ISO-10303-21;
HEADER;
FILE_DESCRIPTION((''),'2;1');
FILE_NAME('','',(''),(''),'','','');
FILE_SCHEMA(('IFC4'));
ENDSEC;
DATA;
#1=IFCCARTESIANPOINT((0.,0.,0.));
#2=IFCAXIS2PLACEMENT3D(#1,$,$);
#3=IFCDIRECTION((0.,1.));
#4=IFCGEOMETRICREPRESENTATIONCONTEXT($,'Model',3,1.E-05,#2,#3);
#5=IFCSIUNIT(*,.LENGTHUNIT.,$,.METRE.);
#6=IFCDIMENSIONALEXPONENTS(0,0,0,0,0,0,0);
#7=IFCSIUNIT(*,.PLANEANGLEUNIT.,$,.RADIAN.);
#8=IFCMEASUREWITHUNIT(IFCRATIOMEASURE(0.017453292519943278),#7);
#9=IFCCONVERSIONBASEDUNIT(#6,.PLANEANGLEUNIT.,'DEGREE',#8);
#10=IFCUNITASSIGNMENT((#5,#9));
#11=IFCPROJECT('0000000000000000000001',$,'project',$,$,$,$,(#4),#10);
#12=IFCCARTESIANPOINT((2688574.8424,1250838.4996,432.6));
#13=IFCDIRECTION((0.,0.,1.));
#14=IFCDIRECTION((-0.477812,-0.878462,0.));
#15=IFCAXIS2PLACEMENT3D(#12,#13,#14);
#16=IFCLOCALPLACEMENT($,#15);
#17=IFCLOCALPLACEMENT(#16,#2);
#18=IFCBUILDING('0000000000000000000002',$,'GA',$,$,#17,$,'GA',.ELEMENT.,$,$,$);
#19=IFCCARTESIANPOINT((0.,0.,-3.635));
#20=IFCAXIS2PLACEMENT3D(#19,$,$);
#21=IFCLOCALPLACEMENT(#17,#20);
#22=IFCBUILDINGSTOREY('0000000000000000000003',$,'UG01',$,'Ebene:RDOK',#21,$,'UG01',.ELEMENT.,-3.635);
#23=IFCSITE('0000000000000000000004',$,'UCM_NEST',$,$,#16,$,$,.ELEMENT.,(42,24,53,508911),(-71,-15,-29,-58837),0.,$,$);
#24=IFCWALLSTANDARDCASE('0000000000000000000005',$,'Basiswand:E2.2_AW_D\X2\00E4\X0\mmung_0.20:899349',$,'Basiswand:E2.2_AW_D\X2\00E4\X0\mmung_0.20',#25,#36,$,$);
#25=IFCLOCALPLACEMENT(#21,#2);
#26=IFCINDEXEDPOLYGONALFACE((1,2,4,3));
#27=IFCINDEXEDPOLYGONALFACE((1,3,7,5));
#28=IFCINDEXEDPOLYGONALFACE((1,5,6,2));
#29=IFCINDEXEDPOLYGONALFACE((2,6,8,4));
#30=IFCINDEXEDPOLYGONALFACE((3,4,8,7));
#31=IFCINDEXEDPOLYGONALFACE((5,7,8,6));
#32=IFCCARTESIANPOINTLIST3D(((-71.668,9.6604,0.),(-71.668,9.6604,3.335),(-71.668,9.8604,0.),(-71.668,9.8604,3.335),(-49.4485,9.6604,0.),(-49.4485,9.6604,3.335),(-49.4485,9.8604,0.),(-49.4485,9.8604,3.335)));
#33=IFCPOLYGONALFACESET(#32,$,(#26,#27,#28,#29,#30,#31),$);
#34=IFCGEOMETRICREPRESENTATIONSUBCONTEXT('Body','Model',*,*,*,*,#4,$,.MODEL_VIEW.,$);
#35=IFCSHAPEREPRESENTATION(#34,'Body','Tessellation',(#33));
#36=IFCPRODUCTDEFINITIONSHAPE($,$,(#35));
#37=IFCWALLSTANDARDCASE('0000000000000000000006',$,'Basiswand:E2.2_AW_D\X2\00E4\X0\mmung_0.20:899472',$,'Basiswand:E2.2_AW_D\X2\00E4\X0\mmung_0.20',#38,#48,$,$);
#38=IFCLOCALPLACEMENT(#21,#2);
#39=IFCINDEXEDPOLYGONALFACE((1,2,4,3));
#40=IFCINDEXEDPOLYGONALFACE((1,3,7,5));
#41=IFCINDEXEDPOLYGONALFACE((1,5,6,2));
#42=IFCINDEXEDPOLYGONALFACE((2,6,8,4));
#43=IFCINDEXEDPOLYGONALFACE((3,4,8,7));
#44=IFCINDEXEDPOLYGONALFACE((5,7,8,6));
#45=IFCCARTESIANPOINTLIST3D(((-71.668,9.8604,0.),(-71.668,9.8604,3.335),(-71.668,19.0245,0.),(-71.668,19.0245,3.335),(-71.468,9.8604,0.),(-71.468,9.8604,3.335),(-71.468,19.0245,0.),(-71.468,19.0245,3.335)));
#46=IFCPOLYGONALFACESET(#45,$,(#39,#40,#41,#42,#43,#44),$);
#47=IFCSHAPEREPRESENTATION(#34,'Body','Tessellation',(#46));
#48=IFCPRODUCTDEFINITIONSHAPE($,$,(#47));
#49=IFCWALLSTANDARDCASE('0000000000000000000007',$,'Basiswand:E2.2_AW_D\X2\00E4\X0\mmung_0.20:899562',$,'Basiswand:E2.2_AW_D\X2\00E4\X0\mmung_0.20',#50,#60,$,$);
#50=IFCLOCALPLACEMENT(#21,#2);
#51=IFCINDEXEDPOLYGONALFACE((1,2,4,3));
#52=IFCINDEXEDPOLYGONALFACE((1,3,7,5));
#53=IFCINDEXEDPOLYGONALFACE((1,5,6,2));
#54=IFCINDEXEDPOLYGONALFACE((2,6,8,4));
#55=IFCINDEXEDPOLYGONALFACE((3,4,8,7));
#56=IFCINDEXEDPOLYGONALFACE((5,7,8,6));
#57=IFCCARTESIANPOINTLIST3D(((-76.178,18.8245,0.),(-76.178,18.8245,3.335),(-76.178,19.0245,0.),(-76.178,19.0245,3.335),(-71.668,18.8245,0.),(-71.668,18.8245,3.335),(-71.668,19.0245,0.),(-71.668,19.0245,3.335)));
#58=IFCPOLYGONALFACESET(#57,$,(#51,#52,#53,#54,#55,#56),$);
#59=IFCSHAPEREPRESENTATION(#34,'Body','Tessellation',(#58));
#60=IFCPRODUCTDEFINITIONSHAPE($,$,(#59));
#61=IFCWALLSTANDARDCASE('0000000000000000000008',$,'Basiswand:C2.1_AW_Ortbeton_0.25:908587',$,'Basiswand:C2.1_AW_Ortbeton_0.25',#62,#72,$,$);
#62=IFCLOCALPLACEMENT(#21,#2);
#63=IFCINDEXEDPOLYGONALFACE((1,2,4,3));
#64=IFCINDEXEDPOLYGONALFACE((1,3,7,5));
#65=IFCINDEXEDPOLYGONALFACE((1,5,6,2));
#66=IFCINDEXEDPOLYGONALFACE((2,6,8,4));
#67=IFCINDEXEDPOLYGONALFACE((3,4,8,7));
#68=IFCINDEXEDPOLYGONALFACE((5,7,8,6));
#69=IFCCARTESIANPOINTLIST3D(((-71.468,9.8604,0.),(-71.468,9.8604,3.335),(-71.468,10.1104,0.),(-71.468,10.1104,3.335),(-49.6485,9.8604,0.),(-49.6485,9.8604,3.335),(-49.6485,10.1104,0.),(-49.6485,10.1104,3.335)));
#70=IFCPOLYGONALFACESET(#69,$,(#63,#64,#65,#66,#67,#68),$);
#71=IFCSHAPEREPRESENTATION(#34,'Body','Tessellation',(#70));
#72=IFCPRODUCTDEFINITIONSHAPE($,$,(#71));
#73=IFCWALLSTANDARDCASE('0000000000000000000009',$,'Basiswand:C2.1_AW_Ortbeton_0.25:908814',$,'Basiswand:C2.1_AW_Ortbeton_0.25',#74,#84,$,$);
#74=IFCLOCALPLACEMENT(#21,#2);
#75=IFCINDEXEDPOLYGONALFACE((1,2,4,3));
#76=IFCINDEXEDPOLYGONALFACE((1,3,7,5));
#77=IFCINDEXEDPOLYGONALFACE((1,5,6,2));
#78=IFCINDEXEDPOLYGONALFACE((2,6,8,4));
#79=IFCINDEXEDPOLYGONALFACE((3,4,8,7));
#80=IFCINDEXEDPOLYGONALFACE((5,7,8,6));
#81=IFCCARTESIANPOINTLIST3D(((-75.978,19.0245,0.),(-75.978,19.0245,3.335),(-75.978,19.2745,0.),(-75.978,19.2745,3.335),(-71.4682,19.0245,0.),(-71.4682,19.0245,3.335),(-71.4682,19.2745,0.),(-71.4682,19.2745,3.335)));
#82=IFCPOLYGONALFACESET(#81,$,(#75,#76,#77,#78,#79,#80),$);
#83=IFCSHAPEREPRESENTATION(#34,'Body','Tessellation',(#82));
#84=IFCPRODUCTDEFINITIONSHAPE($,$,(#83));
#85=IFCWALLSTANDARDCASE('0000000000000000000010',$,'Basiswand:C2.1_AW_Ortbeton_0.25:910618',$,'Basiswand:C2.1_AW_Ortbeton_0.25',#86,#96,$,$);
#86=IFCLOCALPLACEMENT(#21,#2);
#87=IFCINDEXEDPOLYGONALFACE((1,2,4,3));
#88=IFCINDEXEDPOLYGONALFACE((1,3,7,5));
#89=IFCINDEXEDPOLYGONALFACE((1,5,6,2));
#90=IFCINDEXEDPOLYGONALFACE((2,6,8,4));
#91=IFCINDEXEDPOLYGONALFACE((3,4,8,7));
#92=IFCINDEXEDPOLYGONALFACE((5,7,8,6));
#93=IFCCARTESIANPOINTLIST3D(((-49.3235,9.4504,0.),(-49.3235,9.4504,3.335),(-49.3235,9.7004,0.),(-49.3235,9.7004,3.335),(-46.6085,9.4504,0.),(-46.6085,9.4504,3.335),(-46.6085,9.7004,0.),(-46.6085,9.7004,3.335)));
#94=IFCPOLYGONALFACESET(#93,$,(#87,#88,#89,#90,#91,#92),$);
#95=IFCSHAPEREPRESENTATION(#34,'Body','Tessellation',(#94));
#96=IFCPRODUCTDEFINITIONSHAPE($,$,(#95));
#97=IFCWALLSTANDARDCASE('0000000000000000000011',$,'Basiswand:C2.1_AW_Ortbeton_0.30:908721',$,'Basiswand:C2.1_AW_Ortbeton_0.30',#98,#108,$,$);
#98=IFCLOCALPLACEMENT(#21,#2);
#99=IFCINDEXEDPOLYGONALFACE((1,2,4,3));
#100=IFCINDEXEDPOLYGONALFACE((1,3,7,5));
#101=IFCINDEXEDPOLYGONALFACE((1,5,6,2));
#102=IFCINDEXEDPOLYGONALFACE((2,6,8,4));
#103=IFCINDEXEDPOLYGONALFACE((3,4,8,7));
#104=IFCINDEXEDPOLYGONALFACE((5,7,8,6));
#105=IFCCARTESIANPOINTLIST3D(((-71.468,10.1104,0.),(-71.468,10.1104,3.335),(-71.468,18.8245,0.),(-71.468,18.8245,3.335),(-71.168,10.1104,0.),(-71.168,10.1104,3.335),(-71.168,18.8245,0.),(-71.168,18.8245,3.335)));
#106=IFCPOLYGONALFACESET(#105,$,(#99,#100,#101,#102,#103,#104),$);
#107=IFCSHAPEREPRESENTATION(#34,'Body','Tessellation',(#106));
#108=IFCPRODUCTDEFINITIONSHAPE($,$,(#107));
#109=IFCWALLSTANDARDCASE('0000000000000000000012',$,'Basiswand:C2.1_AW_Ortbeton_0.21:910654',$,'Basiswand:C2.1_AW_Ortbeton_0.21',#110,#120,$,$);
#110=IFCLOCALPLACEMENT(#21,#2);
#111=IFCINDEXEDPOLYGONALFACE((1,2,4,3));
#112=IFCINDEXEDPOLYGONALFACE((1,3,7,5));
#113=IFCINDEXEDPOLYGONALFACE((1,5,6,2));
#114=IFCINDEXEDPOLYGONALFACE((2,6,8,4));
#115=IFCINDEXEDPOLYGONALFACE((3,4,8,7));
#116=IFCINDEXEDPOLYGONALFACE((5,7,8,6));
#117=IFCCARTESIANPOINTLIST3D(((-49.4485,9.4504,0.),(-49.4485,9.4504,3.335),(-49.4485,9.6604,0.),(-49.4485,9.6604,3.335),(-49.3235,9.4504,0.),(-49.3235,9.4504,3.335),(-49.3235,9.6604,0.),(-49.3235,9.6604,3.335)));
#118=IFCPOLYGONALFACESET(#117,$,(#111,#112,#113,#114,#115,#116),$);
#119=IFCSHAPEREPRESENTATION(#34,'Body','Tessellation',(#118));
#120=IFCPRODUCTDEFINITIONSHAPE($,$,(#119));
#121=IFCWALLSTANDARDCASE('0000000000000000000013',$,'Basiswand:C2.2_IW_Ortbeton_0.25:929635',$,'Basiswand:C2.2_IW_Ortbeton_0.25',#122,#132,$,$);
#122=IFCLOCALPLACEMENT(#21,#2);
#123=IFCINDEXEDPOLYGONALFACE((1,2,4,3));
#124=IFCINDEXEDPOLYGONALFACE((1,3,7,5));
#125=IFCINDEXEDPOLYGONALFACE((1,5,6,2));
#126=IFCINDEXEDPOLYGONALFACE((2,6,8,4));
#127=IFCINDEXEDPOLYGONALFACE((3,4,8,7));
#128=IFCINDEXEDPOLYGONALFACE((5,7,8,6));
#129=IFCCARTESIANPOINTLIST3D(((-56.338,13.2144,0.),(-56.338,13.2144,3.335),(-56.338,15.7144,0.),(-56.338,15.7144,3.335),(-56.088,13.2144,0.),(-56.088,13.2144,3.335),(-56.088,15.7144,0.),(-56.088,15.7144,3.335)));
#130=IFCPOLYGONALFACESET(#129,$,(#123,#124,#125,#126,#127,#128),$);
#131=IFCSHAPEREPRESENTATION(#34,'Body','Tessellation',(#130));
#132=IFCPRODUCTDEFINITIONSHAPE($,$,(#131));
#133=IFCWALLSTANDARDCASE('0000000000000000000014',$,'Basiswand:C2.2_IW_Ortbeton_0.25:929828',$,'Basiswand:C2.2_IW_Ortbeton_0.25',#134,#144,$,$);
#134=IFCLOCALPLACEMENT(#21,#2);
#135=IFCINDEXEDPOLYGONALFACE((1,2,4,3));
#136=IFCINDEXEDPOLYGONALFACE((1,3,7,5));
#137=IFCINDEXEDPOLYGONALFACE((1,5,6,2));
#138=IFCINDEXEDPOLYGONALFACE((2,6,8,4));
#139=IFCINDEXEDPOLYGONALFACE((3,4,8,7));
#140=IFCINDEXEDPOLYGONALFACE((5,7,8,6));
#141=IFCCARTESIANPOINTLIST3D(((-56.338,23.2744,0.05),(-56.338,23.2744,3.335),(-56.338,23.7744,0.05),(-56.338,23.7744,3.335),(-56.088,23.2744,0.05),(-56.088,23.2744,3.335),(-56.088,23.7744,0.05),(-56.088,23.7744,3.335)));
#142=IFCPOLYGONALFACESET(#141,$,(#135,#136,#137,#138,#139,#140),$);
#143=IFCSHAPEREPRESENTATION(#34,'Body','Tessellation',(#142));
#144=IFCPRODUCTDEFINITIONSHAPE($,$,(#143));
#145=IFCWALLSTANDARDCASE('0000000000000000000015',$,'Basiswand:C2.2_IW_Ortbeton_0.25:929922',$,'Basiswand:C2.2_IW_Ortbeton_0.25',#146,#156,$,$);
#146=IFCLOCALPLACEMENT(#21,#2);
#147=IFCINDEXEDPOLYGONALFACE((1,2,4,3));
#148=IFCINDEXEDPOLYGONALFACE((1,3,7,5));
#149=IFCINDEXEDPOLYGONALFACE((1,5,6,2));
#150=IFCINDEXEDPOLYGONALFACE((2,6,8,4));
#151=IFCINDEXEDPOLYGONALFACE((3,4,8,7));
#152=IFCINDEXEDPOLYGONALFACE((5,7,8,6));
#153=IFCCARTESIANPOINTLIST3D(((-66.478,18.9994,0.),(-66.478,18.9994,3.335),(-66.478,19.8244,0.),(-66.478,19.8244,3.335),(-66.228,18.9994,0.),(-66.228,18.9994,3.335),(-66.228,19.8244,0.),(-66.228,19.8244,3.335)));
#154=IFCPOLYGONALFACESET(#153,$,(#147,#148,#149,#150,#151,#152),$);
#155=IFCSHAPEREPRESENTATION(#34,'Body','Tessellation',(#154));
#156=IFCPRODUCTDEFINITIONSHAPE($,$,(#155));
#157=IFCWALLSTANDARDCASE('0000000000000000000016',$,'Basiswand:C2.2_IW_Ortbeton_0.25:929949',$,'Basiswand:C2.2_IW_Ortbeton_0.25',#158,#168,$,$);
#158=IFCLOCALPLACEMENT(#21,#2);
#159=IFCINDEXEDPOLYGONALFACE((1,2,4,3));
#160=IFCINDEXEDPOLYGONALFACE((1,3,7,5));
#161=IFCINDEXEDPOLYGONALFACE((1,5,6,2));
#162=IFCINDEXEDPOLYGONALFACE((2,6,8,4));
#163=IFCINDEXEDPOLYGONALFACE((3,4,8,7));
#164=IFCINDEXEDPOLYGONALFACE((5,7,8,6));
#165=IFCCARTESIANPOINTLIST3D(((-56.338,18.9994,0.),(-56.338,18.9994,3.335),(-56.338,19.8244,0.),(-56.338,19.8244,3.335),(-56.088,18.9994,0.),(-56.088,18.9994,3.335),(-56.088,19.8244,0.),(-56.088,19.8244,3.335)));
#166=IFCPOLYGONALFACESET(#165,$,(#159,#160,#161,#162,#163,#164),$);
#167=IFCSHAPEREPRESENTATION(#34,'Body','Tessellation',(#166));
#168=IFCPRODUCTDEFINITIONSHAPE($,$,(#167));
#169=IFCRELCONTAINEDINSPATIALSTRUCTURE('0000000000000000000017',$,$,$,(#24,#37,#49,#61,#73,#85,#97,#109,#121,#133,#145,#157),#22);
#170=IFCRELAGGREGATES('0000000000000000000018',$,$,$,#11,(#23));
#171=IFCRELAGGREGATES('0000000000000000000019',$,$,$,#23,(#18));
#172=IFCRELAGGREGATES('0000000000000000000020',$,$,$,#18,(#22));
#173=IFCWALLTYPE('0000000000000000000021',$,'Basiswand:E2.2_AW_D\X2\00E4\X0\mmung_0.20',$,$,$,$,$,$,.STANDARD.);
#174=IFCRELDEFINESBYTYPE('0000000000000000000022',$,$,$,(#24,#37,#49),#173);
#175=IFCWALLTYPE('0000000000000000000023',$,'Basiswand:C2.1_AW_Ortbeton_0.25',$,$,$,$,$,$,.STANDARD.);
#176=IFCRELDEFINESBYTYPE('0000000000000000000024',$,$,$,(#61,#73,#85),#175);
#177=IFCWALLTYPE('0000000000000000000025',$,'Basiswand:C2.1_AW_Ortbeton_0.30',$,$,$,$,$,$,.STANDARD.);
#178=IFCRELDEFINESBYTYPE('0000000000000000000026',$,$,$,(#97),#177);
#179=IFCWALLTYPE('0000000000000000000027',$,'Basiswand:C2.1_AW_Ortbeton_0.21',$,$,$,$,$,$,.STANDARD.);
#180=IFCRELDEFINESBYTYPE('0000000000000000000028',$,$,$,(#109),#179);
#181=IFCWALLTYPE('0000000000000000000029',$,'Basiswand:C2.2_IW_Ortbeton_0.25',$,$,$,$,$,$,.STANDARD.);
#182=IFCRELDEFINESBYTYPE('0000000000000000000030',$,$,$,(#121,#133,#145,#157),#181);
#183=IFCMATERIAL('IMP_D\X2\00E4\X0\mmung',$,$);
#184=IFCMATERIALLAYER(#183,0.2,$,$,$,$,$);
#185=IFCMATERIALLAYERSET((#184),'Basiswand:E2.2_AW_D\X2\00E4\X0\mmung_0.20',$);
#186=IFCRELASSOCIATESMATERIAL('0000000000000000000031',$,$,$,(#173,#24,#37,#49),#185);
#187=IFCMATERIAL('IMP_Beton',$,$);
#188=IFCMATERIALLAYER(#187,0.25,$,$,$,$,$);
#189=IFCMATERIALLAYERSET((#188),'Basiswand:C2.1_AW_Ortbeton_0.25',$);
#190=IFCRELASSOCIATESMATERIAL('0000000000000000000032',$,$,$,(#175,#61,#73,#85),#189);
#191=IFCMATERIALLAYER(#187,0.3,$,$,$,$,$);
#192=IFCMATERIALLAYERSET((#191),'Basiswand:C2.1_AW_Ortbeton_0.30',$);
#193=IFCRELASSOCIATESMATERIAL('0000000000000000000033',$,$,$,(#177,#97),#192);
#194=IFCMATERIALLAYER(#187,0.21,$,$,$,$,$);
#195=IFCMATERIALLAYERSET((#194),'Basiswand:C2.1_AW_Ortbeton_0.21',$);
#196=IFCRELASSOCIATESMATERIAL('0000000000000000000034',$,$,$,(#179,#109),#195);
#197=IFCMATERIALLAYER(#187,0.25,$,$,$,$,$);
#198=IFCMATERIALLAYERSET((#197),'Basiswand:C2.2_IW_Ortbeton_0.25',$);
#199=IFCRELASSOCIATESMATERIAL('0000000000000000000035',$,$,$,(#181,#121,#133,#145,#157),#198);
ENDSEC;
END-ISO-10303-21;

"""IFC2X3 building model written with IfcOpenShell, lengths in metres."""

from ifc_helpers import new_model, entity, si_unit, converted_unit, direction, frame, frame_2d, origin, place, context, subcontext, project, spatial, polyline, rectangle, extrude, clip, bounded_halfspace, material, layer, layer_set, layer_usage, type_object, element, save


model = new_model("IFC2X3")

# Units and contexts
model_context = context("Model", 3, precision=1e-05, world=origin(), true_north=direction((0.0, 1.0)))
body_context = subcontext(model_context, "Body", "Model", "MODEL_VIEW")
ifc_project = project(units=[si_unit("LENGTHUNIT", "METRE"), converted_unit("PLANEANGLEUNIT", "DEGREE", entity("IfcRatioMeasure", 0.017453292519943278), si_unit("PLANEANGLEUNIT", "RADIAN"), dimensions=[0, 0, 0, 0, 0, 0, 0])], contexts=[model_context])

# Site, building, storey
site_placement = place(None, frame((2688574.8424, 1250838.4996, 432.6), z_axis=(0.0, 0.0, 1.0), x_axis=(-0.477812, -0.878462, 0.0)))
site = spatial("IfcSite", under=ifc_project, at=site_placement, Name="UCM_NEST", CompositionType="ELEMENT", RefLatitude=(42, 24, 53, 508911), RefLongitude=(-71, -15, -29, -58837), RefElevation=0.0)
building_placement = place(site_placement, origin())
building = spatial("IfcBuilding", under=site, at=building_placement, Name="GA", LongName="GA", CompositionType="ELEMENT")
storey_placement = place(building_placement, frame((0.0, 0.0, -3.635)))
storey = spatial("IfcBuildingStorey", under=building, at=storey_placement, Name="UG01", ObjectType="Ebene:RDOK", LongName="UG01", CompositionType="ELEMENT", Elevation=-3.635)

# Walls
ifc_material_1 = material(Name="IMP_Dämmung")
ifc_layer_1 = layer(ifc_material_1, 0.2)
ifc_layer_set_1 = layer_set([ifc_layer_1], Name="Basiswand:E2.2_AW_Dämmung_0.20")
ifc_layer_usage_1 = layer_usage(ifc_layer_set_1, "AXIS2", "NEGATIVE", 0.1)
wall_type_1 = type_object("IfcWallType", Name="Basiswand:E2.2_AW_Dämmung_0.20", PredefinedType="STANDARD", material=ifc_layer_set_1)
wall_1_placement = place(storey_placement, frame((-49.4485, 9.7604, 0.0), z_axis=(0.0, 0.0, 1.0), x_axis=(-1.0, 0.0, 0.0)))
element("IfcWallStandardCase", 1, at=wall_1_placement, inside=storey, type_object=wall_type_1, material=ifc_layer_usage_1, Name="Basiswand:E2.2_AW_Dämmung_0.20:899349", ObjectType="Basiswand:E2.2_AW_Dämmung_0.20", context=body_context, shape_type="SweptSolid", body=[
    extrude(rectangle(XDim=22.2195, YDim=0.2, at=frame_2d((11.1097, 0.0), x_axis=(-1.0, 0.0))), origin(), (0.0, 0.0, 1.0), 3.335),
])
wall_2_placement = place(storey_placement, frame((-71.568, 9.8604, 0.0), z_axis=(0.0, 0.0, 1.0), x_axis=(0.0, 1.0, 0.0)))
element("IfcWallStandardCase", 2, at=wall_2_placement, inside=storey, type_object=wall_type_1, material=ifc_layer_usage_1, Name="Basiswand:E2.2_AW_Dämmung_0.20:899472", ObjectType="Basiswand:E2.2_AW_Dämmung_0.20", context=body_context, shape_type="SweptSolid", body=[
    extrude(rectangle(XDim=9.164, YDim=0.2, at=frame_2d((4.582, 0.0), x_axis=(-1.0, 0.0))), origin(), (0.0, 0.0, 1.0), 3.335),
])
wall_3_placement = place(storey_placement, frame((-71.668, 18.9245, 0.0), z_axis=(0.0, 0.0, 1.0), x_axis=(-1.0, 0.0, 0.0)))
element("IfcWallStandardCase", 3, at=wall_3_placement, inside=storey, type_object=wall_type_1, material=ifc_layer_usage_1, Name="Basiswand:E2.2_AW_Dämmung_0.20:899562", ObjectType="Basiswand:E2.2_AW_Dämmung_0.20", context=body_context, shape_type="SweptSolid", body=[
    extrude(rectangle(XDim=4.51, YDim=0.2, at=frame_2d((2.255, 0.0), x_axis=(-1.0, 0.0))), origin(), (0.0, 0.0, 1.0), 3.335),
])
ifc_material_2 = material(Name="IMP_Beton")
ifc_layer_2 = layer(ifc_material_2, 0.25)
ifc_layer_set_2 = layer_set([ifc_layer_2], Name="Basiswand:C2.1_AW_Ortbeton_0.25")
ifc_layer_usage_2 = layer_usage(ifc_layer_set_2, "AXIS2", "NEGATIVE", 0.125)
wall_type_2 = type_object("IfcWallType", Name="Basiswand:C2.1_AW_Ortbeton_0.25", PredefinedType="STANDARD", material=ifc_layer_set_2)
wall_4_placement = place(storey_placement, frame((-71.468, 9.9854, 0.0)))
element("IfcWallStandardCase", 4, at=wall_4_placement, inside=storey, type_object=wall_type_2, material=ifc_layer_usage_2, Name="Basiswand:C2.1_AW_Ortbeton_0.25:908587", ObjectType="Basiswand:C2.1_AW_Ortbeton_0.25", context=body_context, shape_type="SweptSolid", body=[
    extrude(rectangle(XDim=21.8195, YDim=0.25, at=frame_2d((10.9097, 0.0), x_axis=(-1.0, 0.0))), origin(), (0.0, 0.0, 1.0), 3.335),
])
wall_5_placement = place(storey_placement, frame((-71.4682, 19.1495, 0.0), z_axis=(0.0, 0.0, 1.0), x_axis=(-1.0, 0.0, 0.0)))
element("IfcWallStandardCase", 5, at=wall_5_placement, inside=storey, type_object=wall_type_2, material=ifc_layer_usage_2, Name="Basiswand:C2.1_AW_Ortbeton_0.25:908814", ObjectType="Basiswand:C2.1_AW_Ortbeton_0.25", context=body_context, shape_type="SweptSolid", body=[
    extrude(rectangle(XDim=4.5097, YDim=0.25, at=frame_2d((2.2549, 0.0), x_axis=(-1.0, 0.0))), origin(), (0.0, 0.0, 1.0), 3.335),
])
wall_6_placement = place(storey_placement, frame((-46.6085, 9.5754, 0.0), z_axis=(0.0, 0.0, 1.0), x_axis=(-1.0, 0.0, 0.0)))
element("IfcWallStandardCase", 6, at=wall_6_placement, inside=storey, type_object=wall_type_2, material=ifc_layer_usage_2, Name="Basiswand:C2.1_AW_Ortbeton_0.25:910618", ObjectType="Basiswand:C2.1_AW_Ortbeton_0.25", context=body_context, shape_type="SweptSolid", body=[
    extrude(rectangle(XDim=2.715, YDim=0.25, at=frame_2d((1.3575, 0.0), x_axis=(-1.0, 0.0))), origin(), (0.0, 0.0, 1.0), 3.335),
])
ifc_layer_3 = layer(ifc_material_2, 0.3)
ifc_layer_set_3 = layer_set([ifc_layer_3], Name="Basiswand:C2.1_AW_Ortbeton_0.30")
ifc_layer_usage_3 = layer_usage(ifc_layer_set_3, "AXIS2", "NEGATIVE", 0.15)
wall_type_3 = type_object("IfcWallType", Name="Basiswand:C2.1_AW_Ortbeton_0.30", PredefinedType="STANDARD", material=ifc_layer_set_3)
wall_7_placement = place(storey_placement, frame((-71.318, 10.1104, 0.0), z_axis=(0.0, 0.0, 1.0), x_axis=(0.0, 1.0, 0.0)))
element("IfcWallStandardCase", 7, at=wall_7_placement, inside=storey, type_object=wall_type_3, material=ifc_layer_usage_3, Name="Basiswand:C2.1_AW_Ortbeton_0.30:908721", ObjectType="Basiswand:C2.1_AW_Ortbeton_0.30", context=body_context, shape_type="SweptSolid", body=[
    extrude(rectangle(XDim=8.714, YDim=0.3, at=frame_2d((4.357, 0.0), x_axis=(-1.0, 0.0))), origin(), (0.0, 0.0, 1.0), 3.335),
])
ifc_layer_4 = layer(ifc_material_2, 0.21)
ifc_layer_set_4 = layer_set([ifc_layer_4], Name="Basiswand:C2.1_AW_Ortbeton_0.21")
ifc_layer_usage_4 = layer_usage(ifc_layer_set_4, "AXIS2", "NEGATIVE", 0.105)
wall_type_4 = type_object("IfcWallType", Name="Basiswand:C2.1_AW_Ortbeton_0.21", PredefinedType="STANDARD", material=ifc_layer_set_4)
wall_8_placement = place(storey_placement, frame((-49.3235, 9.5554, 0.0), z_axis=(0.0, 0.0, 1.0), x_axis=(-1.0, 0.0, 0.0)))
element("IfcWallStandardCase", 8, at=wall_8_placement, inside=storey, type_object=wall_type_4, material=ifc_layer_usage_4, Name="Basiswand:C2.1_AW_Ortbeton_0.21:910654", ObjectType="Basiswand:C2.1_AW_Ortbeton_0.21", context=body_context, shape_type="SweptSolid", body=[
    extrude(rectangle(XDim=0.125, YDim=0.21, at=frame_2d((0.0625, 0.0), x_axis=(-1.0, 0.0))), origin(), (0.0, 0.0, 1.0), 3.335),
])
ifc_layer_5 = layer(ifc_material_2, 0.25)
ifc_layer_set_5 = layer_set([ifc_layer_5], Name="Basiswand:C2.2_IW_Ortbeton_0.25")
ifc_layer_usage_5 = layer_usage(ifc_layer_set_5, "AXIS2", "NEGATIVE", 0.125)
wall_type_5 = type_object("IfcWallType", Name="Basiswand:C2.2_IW_Ortbeton_0.25", PredefinedType="STANDARD", material=ifc_layer_set_5)
wall_9_placement = place(storey_placement, frame((-56.213, 13.2144, 0.0), z_axis=(0.0, 0.0, 1.0), x_axis=(0.0, 1.0, 0.0)))
element("IfcWallStandardCase", 9, at=wall_9_placement, inside=storey, type_object=wall_type_5, material=ifc_layer_usage_5, Name="Basiswand:C2.2_IW_Ortbeton_0.25:929635", ObjectType="Basiswand:C2.2_IW_Ortbeton_0.25", context=body_context, shape_type="SweptSolid", body=[
    extrude(rectangle(XDim=2.5, YDim=0.25, at=frame_2d((1.25, 0.0), x_axis=(-1.0, 0.0))), origin(), (0.0, 0.0, 1.0), 3.335),
])
wall_10_placement = place(storey_placement, frame((-56.213, 23.7744, 0.05), z_axis=(0.0, 0.0, 1.0), x_axis=(0.0, -1.0, 0.0)))
element("IfcWallStandardCase", 10, at=wall_10_placement, inside=storey, type_object=wall_type_5, material=ifc_layer_usage_5, Name="Basiswand:C2.2_IW_Ortbeton_0.25:929828", ObjectType="Basiswand:C2.2_IW_Ortbeton_0.25", context=body_context, shape_type="Clipping", body=[
    clip(extrude(rectangle(XDim=0.5, YDim=0.25, at=frame_2d((0.25, 0.0), x_axis=(-1.0, 0.0))), origin(), (0.0, 0.0, 1.0), 3.285), bounded_halfspace(frame((0.5, -0.125, 0.0), z_axis=(0.0, 0.0, 1.0), x_axis=(-1.0, 0.0, 0.0)), True, frame((0.5, -0.125, 0.0), z_axis=(0.0, 0.0, 1.0), x_axis=(-1.0, 0.0, 0.0)), polyline([(0.0, 0.0), (0.0, -0.25), (0.5, -0.25), (0.5, 0.0), (0.0, 0.0)]))),
])
wall_11_placement = place(storey_placement, frame((-66.353, 19.8244, 0.0), z_axis=(0.0, 0.0, 1.0), x_axis=(0.0, -1.0, 0.0)))
element("IfcWallStandardCase", 11, at=wall_11_placement, inside=storey, type_object=wall_type_5, material=ifc_layer_usage_5, Name="Basiswand:C2.2_IW_Ortbeton_0.25:929922", ObjectType="Basiswand:C2.2_IW_Ortbeton_0.25", context=body_context, shape_type="SweptSolid", body=[
    extrude(rectangle(XDim=0.825, YDim=0.25, at=frame_2d((0.4125, 0.0), x_axis=(-1.0, 0.0))), origin(), (0.0, 0.0, 1.0), 3.335),
])
wall_12_placement = place(storey_placement, frame((-56.213, 19.8244, 0.0), z_axis=(0.0, 0.0, 1.0), x_axis=(0.0, -1.0, 0.0)))
element("IfcWallStandardCase", 12, at=wall_12_placement, inside=storey, type_object=wall_type_5, material=ifc_layer_usage_5, Name="Basiswand:C2.2_IW_Ortbeton_0.25:929949", ObjectType="Basiswand:C2.2_IW_Ortbeton_0.25", context=body_context, shape_type="SweptSolid", body=[
    extrude(rectangle(XDim=0.825, YDim=0.25, at=frame_2d((0.4125, 0.0), x_axis=(-1.0, 0.0))), origin(), (0.0, 0.0, 1.0), 3.335),
])

save(model, "model.ifc")
